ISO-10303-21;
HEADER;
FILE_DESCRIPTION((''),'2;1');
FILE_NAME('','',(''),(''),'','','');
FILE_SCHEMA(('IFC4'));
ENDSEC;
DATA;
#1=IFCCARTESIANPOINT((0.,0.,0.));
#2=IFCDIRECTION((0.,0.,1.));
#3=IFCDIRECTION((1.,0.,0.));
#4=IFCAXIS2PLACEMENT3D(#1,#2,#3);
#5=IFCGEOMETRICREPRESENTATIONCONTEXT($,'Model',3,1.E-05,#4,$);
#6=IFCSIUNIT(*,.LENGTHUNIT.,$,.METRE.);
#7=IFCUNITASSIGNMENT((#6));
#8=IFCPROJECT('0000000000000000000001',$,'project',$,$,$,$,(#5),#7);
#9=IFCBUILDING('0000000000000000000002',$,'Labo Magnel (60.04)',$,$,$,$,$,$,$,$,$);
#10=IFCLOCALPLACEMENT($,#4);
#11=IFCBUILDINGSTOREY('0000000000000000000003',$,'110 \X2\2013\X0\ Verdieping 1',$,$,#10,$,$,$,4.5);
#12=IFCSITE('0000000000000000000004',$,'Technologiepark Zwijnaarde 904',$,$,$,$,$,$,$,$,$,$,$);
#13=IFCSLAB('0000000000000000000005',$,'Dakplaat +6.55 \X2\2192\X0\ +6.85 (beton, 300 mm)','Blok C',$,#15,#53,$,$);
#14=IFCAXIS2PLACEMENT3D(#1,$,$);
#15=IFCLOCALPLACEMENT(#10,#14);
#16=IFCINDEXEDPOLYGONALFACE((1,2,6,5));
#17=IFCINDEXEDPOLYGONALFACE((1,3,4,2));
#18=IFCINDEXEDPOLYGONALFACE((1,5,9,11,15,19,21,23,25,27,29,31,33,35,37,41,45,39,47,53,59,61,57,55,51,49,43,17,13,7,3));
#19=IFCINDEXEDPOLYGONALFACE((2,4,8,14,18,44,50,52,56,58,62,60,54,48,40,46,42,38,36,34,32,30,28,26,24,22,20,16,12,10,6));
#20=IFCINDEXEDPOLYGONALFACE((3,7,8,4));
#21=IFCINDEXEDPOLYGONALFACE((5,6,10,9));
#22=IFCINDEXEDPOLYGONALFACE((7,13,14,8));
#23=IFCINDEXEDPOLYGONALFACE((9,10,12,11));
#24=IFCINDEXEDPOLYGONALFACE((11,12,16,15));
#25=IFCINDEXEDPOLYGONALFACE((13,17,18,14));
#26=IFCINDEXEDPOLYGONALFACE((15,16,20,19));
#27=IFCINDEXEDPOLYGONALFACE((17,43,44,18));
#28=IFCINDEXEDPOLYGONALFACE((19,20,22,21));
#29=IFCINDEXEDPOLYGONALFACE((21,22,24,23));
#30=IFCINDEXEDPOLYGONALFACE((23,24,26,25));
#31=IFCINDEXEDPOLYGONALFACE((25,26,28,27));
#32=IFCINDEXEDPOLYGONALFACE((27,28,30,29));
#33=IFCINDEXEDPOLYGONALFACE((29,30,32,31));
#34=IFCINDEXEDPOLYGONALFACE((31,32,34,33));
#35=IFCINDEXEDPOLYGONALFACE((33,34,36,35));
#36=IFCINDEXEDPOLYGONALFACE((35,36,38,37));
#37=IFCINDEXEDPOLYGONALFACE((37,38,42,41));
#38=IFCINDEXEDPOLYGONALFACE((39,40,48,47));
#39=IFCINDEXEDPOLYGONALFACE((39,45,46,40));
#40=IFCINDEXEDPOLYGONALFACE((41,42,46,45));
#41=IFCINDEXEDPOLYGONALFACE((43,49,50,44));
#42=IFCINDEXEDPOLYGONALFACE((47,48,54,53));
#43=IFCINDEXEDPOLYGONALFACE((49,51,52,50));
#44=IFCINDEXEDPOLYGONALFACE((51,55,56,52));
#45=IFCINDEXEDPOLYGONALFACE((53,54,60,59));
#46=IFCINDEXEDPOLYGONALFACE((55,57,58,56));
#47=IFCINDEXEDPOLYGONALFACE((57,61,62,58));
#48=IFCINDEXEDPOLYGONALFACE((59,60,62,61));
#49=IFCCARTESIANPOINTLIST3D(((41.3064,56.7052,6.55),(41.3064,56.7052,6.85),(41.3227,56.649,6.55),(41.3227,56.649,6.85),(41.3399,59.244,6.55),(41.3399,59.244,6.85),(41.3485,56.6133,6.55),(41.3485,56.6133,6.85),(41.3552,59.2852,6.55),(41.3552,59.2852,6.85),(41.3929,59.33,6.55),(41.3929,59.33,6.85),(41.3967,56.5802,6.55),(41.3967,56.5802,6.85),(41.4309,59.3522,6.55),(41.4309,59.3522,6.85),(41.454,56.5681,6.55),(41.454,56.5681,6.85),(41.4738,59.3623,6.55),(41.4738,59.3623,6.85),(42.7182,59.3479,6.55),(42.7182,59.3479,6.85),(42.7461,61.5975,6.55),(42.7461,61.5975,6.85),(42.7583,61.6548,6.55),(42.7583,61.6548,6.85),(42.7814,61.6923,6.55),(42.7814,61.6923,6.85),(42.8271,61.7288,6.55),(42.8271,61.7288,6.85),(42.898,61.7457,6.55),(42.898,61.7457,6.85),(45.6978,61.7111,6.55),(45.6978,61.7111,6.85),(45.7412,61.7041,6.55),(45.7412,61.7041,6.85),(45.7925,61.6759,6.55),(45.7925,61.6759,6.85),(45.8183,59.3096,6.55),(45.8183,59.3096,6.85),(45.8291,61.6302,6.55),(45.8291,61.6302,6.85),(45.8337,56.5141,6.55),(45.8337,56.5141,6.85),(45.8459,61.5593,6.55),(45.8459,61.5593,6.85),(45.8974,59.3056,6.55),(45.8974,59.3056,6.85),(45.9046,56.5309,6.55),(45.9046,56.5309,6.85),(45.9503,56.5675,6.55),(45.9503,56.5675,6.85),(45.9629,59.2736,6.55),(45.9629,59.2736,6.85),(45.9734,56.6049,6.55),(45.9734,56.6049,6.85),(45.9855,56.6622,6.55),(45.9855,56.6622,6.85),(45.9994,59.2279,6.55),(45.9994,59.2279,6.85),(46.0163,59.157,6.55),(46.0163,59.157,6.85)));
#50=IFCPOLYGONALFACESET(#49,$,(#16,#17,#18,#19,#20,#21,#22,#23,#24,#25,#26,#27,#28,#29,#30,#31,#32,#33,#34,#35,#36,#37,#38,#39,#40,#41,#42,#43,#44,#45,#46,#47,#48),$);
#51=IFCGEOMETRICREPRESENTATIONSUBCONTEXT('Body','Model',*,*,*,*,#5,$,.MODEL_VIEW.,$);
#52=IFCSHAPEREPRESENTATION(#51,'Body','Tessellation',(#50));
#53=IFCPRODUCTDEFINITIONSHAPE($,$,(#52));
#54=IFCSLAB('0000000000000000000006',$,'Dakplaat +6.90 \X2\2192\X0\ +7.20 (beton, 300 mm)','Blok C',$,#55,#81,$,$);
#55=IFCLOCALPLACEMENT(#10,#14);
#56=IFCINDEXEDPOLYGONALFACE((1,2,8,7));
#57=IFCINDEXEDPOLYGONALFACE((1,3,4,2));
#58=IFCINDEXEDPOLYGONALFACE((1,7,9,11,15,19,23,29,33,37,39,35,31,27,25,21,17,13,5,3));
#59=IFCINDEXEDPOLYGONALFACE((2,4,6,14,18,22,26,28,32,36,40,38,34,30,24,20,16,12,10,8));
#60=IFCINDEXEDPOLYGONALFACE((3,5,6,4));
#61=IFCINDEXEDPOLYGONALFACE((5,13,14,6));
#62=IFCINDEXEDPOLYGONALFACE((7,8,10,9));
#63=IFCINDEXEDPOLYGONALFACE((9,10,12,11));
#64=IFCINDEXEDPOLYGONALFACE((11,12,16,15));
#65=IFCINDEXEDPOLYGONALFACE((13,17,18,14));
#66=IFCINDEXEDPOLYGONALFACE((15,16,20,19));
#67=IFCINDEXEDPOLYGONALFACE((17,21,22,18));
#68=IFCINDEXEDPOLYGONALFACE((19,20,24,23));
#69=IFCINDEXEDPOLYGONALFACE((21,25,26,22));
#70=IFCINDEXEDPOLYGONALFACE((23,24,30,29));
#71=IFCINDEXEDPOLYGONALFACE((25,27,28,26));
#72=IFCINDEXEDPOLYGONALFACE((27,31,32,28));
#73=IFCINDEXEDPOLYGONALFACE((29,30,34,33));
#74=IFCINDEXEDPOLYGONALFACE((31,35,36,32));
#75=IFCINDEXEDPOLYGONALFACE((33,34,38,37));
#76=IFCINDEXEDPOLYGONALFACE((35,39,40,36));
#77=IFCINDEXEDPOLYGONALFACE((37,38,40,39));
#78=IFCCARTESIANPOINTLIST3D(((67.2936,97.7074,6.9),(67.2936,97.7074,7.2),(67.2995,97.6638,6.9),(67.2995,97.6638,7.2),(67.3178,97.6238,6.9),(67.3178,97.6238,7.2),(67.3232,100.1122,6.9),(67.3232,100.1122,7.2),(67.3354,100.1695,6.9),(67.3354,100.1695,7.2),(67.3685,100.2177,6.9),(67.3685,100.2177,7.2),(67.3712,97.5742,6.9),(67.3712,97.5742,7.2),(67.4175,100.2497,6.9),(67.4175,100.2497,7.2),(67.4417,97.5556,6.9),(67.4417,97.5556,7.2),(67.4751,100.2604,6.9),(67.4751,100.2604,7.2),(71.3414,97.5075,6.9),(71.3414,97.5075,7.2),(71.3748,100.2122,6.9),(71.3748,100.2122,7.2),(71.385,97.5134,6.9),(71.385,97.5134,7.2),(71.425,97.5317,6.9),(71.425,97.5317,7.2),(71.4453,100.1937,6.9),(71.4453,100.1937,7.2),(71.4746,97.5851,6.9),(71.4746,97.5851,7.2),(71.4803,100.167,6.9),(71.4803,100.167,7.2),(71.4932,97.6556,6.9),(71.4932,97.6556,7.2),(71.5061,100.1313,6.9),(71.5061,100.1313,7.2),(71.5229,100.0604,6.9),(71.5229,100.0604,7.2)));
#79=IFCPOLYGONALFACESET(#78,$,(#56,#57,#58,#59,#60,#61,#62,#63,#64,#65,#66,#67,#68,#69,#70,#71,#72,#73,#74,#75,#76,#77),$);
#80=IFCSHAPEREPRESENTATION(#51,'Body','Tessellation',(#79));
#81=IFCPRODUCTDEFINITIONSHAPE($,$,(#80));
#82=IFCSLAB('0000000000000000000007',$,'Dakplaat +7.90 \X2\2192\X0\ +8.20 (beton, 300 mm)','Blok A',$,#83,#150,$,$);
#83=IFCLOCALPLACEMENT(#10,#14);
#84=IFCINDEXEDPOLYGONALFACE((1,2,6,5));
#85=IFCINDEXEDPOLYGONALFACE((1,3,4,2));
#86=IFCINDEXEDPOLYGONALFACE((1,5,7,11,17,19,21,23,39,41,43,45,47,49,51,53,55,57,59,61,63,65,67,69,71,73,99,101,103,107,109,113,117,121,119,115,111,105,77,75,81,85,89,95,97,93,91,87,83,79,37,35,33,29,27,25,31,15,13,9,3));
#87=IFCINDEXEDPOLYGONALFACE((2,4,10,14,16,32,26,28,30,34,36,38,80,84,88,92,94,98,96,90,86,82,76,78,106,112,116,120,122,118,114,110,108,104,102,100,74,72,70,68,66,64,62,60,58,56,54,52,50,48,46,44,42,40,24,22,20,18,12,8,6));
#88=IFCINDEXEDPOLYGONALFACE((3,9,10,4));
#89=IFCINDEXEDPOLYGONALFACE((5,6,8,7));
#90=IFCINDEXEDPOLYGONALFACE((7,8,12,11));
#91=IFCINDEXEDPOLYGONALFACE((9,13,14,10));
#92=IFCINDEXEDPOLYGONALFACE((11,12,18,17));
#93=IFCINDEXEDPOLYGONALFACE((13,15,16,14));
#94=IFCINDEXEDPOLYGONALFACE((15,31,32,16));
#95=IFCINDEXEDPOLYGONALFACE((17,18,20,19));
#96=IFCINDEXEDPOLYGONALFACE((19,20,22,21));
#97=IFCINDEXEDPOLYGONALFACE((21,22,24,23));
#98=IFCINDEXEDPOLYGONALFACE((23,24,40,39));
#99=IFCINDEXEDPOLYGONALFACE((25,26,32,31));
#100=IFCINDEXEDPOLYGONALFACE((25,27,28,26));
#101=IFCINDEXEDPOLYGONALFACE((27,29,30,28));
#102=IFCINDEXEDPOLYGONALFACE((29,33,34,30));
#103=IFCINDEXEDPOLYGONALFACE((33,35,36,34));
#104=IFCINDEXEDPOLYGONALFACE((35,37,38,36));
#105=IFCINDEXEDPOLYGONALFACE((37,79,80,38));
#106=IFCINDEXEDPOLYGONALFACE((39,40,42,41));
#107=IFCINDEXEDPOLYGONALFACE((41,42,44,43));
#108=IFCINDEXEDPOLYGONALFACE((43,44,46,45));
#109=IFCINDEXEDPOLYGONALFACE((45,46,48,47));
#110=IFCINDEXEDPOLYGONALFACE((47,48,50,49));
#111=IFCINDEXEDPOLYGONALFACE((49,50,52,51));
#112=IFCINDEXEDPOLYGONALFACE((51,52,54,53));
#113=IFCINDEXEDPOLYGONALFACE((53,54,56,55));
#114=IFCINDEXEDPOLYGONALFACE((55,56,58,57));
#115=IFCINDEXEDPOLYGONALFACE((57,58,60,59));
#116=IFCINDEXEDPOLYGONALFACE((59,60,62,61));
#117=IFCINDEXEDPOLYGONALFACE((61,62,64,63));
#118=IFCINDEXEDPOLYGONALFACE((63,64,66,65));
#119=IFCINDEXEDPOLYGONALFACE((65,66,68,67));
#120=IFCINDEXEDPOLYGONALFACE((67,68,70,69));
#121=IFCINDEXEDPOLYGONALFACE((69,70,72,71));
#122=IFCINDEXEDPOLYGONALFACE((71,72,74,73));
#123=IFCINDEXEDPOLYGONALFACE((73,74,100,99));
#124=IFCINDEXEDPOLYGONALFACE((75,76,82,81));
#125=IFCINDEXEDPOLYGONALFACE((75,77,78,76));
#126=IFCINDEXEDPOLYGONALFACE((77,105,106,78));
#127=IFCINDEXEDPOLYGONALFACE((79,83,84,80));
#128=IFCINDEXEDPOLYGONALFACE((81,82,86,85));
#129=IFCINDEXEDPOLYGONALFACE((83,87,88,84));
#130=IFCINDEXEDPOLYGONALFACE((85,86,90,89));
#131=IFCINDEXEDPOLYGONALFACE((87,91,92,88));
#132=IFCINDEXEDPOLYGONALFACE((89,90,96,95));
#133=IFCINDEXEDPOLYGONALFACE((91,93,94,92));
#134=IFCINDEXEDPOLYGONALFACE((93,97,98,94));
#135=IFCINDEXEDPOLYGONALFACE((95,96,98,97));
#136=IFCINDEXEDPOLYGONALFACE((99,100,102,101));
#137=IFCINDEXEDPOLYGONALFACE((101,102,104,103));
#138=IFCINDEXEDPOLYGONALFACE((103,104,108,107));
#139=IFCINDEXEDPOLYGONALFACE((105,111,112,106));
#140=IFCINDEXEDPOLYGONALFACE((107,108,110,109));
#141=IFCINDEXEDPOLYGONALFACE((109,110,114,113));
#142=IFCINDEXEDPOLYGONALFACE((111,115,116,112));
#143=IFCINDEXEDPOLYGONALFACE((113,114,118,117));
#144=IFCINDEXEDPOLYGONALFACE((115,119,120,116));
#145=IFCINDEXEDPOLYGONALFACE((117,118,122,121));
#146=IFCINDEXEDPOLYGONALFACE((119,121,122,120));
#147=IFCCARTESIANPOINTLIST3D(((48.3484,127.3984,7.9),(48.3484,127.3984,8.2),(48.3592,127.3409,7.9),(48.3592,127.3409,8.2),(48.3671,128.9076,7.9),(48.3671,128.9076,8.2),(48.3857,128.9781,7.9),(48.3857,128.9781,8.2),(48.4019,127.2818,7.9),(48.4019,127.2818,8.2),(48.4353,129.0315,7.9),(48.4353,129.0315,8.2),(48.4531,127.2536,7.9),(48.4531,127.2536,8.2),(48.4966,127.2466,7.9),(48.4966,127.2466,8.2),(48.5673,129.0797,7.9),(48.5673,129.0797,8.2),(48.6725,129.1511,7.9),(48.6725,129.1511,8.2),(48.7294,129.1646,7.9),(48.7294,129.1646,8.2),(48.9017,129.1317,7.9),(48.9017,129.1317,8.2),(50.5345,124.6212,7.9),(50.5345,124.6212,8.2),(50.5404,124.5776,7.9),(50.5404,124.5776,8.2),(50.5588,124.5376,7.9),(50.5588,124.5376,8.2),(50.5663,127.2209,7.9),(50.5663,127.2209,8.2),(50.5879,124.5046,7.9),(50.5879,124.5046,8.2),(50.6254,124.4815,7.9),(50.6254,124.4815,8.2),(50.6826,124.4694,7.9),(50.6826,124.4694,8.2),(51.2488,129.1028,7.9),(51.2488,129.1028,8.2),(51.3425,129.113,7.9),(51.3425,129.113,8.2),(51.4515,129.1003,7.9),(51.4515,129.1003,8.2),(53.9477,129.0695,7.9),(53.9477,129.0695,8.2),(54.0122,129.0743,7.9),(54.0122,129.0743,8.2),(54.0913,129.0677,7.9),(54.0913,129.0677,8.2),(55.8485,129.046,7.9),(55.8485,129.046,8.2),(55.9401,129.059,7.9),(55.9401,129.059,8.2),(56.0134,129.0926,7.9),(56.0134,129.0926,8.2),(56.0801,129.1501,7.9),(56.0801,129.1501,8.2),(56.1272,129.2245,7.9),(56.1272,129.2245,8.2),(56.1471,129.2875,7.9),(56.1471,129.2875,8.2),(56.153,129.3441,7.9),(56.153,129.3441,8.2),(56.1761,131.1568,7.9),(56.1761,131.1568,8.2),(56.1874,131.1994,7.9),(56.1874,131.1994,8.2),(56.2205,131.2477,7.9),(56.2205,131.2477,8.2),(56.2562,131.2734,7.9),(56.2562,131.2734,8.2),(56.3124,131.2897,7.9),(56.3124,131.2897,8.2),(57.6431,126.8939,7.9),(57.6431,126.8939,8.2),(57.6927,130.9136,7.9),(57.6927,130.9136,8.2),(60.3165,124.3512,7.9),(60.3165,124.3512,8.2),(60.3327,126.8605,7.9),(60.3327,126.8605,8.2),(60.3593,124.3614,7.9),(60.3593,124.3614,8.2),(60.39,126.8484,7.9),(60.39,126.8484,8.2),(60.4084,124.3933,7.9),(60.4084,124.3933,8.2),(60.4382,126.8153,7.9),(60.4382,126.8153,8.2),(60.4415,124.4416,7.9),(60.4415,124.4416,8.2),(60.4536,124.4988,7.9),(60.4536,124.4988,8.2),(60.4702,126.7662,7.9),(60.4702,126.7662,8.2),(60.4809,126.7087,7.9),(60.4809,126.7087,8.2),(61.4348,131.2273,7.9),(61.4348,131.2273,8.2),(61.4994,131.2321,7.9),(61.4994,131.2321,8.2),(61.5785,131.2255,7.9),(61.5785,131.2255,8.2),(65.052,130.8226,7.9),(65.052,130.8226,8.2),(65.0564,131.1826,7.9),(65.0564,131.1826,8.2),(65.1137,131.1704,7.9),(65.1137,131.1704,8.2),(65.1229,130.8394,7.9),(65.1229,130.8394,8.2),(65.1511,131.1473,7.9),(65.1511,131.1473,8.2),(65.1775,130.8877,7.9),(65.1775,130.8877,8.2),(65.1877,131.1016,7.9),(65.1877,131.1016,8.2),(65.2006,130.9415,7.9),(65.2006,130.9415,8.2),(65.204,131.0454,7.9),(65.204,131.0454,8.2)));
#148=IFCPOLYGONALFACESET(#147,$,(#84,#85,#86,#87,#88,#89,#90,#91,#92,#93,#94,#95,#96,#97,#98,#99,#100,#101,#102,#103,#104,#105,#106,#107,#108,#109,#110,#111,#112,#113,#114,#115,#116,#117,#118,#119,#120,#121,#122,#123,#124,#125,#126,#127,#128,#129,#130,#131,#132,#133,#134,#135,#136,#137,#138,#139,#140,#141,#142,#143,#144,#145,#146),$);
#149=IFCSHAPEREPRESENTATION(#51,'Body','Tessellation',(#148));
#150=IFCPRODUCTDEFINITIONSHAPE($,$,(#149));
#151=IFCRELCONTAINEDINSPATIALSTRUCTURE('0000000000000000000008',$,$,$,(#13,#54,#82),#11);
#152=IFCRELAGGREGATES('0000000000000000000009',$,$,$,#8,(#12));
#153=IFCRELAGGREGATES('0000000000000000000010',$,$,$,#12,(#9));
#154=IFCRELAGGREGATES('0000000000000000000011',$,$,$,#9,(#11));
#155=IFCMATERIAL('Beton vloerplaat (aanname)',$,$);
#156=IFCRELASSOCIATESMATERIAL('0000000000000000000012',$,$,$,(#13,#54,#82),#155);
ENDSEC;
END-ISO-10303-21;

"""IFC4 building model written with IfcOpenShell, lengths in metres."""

from ifc_helpers import new_model, si_unit, frame, origin, origin_with_axes, place, context, subcontext, project, spatial, polyline, outline, extrude, material, element, save


model = new_model("IFC4")

# Units and contexts
model_context = context("Model", 3, precision=1e-05, world=origin_with_axes())
body_context = subcontext(model_context, "Body", "Model", "MODEL_VIEW")
ifc_project = project(units=[si_unit("LENGTHUNIT", "METRE")], contexts=[model_context])

# Site, building, storey
site = spatial("IfcSite", under=ifc_project, Name="Technologiepark Zwijnaarde 904")
building = spatial("IfcBuilding", under=site, Name="Labo Magnel (60.04)")
storey_placement = place(None, origin_with_axes())
storey = spatial("IfcBuildingStorey", under=building, at=storey_placement, Name="110 – Verdieping 1", Elevation=4.5)

# Slabs
ifc_material_1 = material(Name="Beton vloerplaat (aanname)")
slab_1_placement = place(storey_placement, frame((0.0, 0.0, 6.55), z_axis=(0.0, 0.0, 1.0), x_axis=(1.0, 0.0, 0.0)))
element("IfcSlab", 1, at=slab_1_placement, inside=storey, material=ifc_material_1, Name="Dakplaat +6.55 → +6.85 (beton, 300 mm)", Description="Blok C", context=body_context, shape_type="SweptSolid", body=[
    extrude(outline(polyline([(41.454, 56.5681), (41.3967, 56.5802), (41.3485, 56.6133), (41.3227, 56.649), (41.3064, 56.7052), (41.3399, 59.244), (41.3552, 59.2852), (41.3929, 59.33), (41.4309, 59.3522), (41.4738, 59.3623), (42.7182, 59.3479), (42.7461, 61.5975), (42.7583, 61.6548), (42.7814, 61.6923), (42.8271, 61.7288), (42.898, 61.7457), (45.6978, 61.7111), (45.7412, 61.7041), (45.7925, 61.6759), (45.8291, 61.6302), (45.8459, 61.5593), (45.8183, 59.3096), (45.8974, 59.3056), (45.9629, 59.2736), (45.9994, 59.2279), (46.0163, 59.157), (45.9855, 56.6622), (45.9734, 56.6049), (45.9503, 56.5675), (45.9046, 56.5309), (45.8337, 56.5141), (41.454, 56.5681)])), origin(), (0.0, 0.0, 1.0), 0.3),
])
slab_2_placement = place(storey_placement, frame((0.0, 0.0, 6.9), z_axis=(0.0, 0.0, 1.0), x_axis=(1.0, 0.0, 0.0)))
element("IfcSlab", 2, at=slab_2_placement, inside=storey, material=ifc_material_1, Name="Dakplaat +6.90 → +7.20 (beton, 300 mm)", Description="Blok C", context=body_context, shape_type="SweptSolid", body=[
    extrude(outline(polyline([(67.3232, 100.1122), (67.3354, 100.1695), (67.3685, 100.2177), (67.4175, 100.2497), (67.4751, 100.2604), (71.3748, 100.2122), (71.4453, 100.1937), (71.4803, 100.167), (71.5061, 100.1313), (71.5229, 100.0604), (71.4932, 97.6556), (71.4746, 97.5851), (71.425, 97.5317), (71.385, 97.5134), (71.3414, 97.5075), (67.4417, 97.5556), (67.3712, 97.5742), (67.3178, 97.6238), (67.2995, 97.6638), (67.2936, 97.7074), (67.3232, 100.1122)])), origin(), (0.0, 0.0, 1.0), 0.3),
])
slab_3_placement = place(storey_placement, frame((0.0, 0.0, 7.9), z_axis=(0.0, 0.0, 1.0), x_axis=(1.0, 0.0, 0.0)))
element("IfcSlab", 3, at=slab_3_placement, inside=storey, material=ifc_material_1, Name="Dakplaat +7.90 → +8.20 (beton, 300 mm)", Description="Blok A", context=body_context, shape_type="SweptSolid", body=[
    extrude(outline(polyline([(48.3671, 128.9076), (48.3857, 128.9781), (48.4353, 129.0315), (48.5673, 129.0797), (48.6725, 129.1511), (48.7294, 129.1646), (48.9017, 129.1317), (51.2488, 129.1028), (51.3425, 129.113), (51.4515, 129.1003), (53.9477, 129.0695), (54.0122, 129.0743), (54.0913, 129.0677), (55.8485, 129.046), (55.9401, 129.059), (56.0134, 129.0926), (56.0801, 129.1501), (56.1272, 129.2245), (56.1471, 129.2875), (56.153, 129.3441), (56.1761, 131.1568), (56.1874, 131.1994), (56.2205, 131.2477), (56.2562, 131.2734), (56.3124, 131.2897), (61.4348, 131.2273), (61.4994, 131.2321), (61.5785, 131.2255), (65.0564, 131.1826), (65.1137, 131.1704), (65.1511, 131.1473), (65.1877, 131.1016), (65.204, 131.0454), (65.2006, 130.9415), (65.1775, 130.8877), (65.1229, 130.8394), (65.052, 130.8226), (57.6927, 130.9136), (57.6431, 126.8939), (60.3327, 126.8605), (60.39, 126.8484), (60.4382, 126.8153), (60.4702, 126.7662), (60.4809, 126.7087), (60.4536, 124.4988), (60.4415, 124.4416), (60.4084, 124.3933), (60.3593, 124.3614), (60.3165, 124.3512), (50.6826, 124.4694), (50.6254, 124.4815), (50.5879, 124.5046), (50.5588, 124.5376), (50.5404, 124.5776), (50.5345, 124.6212), (50.5663, 127.2209), (48.4966, 127.2466), (48.4531, 127.2536), (48.4019, 127.2818), (48.3592, 127.3409), (48.3484, 127.3984), (48.3671, 128.9076)])), origin(), (0.0, 0.0, 1.0), 0.3),
])

save(model, "model.ifc")
